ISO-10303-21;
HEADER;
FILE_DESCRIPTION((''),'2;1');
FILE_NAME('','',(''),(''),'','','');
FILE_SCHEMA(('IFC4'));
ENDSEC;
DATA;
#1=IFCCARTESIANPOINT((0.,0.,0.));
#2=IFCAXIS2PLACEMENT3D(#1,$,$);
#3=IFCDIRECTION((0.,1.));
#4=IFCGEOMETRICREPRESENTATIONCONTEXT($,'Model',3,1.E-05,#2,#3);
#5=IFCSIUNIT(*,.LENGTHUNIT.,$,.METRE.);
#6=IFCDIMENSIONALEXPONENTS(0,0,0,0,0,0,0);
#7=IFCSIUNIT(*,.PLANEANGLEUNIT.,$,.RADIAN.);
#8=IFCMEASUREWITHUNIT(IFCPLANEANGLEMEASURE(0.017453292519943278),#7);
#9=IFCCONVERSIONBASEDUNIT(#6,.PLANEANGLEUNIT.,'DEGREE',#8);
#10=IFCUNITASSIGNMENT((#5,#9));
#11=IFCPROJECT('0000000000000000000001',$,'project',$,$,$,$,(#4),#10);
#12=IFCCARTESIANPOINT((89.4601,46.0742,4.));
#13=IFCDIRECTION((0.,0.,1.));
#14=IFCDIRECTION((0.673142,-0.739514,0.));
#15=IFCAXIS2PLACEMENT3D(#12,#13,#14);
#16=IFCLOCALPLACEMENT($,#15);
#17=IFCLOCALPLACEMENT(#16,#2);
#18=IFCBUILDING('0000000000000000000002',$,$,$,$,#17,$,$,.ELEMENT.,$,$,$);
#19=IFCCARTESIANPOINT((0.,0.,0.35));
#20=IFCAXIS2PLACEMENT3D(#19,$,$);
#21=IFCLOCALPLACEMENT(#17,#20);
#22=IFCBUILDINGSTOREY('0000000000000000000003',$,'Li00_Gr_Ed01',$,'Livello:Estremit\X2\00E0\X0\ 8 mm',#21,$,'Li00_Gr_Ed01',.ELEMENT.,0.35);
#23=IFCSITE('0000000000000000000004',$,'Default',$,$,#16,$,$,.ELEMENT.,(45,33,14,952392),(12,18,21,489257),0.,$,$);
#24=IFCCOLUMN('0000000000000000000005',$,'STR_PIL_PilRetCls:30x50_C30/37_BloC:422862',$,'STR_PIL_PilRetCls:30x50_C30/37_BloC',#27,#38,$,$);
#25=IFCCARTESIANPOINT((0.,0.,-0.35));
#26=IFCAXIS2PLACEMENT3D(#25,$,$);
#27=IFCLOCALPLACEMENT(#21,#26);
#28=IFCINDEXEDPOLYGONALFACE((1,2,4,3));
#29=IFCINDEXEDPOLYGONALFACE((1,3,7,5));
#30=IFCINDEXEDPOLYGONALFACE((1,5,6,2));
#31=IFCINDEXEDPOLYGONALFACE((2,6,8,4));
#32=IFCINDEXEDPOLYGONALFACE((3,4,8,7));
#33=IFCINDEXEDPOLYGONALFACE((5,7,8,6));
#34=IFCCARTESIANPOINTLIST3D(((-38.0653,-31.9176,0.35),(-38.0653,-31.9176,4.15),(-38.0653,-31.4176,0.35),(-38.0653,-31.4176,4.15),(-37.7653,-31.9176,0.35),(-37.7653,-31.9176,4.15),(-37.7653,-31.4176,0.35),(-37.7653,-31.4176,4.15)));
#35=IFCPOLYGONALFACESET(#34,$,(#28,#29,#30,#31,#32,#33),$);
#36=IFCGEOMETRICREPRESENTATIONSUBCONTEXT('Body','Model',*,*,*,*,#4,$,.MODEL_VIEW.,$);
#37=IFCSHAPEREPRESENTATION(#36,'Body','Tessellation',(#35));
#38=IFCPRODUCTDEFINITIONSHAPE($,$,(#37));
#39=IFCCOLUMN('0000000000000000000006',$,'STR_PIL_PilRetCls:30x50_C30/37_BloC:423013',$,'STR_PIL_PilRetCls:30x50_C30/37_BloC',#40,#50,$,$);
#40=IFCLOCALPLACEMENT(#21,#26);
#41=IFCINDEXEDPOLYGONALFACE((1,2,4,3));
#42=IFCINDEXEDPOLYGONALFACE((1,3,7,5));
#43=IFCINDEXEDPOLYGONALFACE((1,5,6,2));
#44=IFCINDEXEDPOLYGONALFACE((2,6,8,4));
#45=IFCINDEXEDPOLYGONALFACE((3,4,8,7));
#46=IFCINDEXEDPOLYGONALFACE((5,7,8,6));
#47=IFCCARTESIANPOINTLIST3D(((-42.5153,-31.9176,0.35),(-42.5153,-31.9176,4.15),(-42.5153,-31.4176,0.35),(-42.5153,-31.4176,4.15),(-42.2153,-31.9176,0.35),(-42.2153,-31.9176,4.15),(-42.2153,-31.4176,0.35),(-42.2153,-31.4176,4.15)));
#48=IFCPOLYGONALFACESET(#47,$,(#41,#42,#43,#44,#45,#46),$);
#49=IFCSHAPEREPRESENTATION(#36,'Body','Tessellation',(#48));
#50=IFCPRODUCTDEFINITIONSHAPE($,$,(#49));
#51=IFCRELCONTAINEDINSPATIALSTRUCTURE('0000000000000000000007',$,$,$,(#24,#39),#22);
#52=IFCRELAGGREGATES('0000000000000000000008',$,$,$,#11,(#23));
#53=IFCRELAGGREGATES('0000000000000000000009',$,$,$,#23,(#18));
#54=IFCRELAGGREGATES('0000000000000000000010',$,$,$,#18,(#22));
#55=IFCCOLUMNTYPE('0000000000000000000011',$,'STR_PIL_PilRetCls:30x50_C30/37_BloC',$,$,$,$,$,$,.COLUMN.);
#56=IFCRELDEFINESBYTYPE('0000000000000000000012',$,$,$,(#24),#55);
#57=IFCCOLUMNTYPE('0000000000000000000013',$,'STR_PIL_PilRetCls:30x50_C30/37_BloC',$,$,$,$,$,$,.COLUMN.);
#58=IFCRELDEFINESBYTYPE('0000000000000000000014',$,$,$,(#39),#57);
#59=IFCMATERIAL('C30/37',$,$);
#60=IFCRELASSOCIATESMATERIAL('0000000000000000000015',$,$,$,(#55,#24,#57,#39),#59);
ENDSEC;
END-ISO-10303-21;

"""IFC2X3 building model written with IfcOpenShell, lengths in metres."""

from ifc_helpers import new_model, entity, si_unit, converted_unit, direction, frame, frame_2d, origin, place, context, subcontext, project, spatial, rectangle, extrude, source, transform, mapped, material, type_object, type_shapes, element, save


model = new_model("IFC2X3")

# Units and contexts
model_context = context("Model", 3, precision=1e-05, world=origin(), true_north=direction((0.0, 1.0)))
body_context = subcontext(model_context, "Body", "Model", "MODEL_VIEW")
ifc_project = project(units=[si_unit("LENGTHUNIT", "METRE"), converted_unit("PLANEANGLEUNIT", "DEGREE", entity("IfcPlaneAngleMeasure", 0.017453292519943278), si_unit("PLANEANGLEUNIT", "RADIAN"), dimensions=[0, 0, 0, 0, 0, 0, 0])], contexts=[model_context])

# Site, building, storey
site_placement = place(None, frame((89.4601, 46.0742, 4.0), z_axis=(0.0, 0.0, 1.0), x_axis=(0.673142, -0.739514, 0.0)))
site = spatial("IfcSite", under=ifc_project, at=site_placement, Name="Default", CompositionType="ELEMENT", RefLatitude=(45, 33, 14, 952392), RefLongitude=(12, 18, 21, 489257), RefElevation=0.0)
building_placement = place(site_placement, origin())
building = spatial("IfcBuilding", under=site, at=building_placement, CompositionType="ELEMENT")
storey_placement = place(building_placement, frame((0.0, 0.0, 0.35)))
storey = spatial("IfcBuildingStorey", under=building, at=storey_placement, Name="Li00_Gr_Ed01", ObjectType="Livello:Estremità 8 mm", LongName="Li00_Gr_Ed01", CompositionType="ELEMENT", Elevation=0.35)

# Columns
ifc_material_1 = material(Name="C30/37")
column_type_1 = type_object("IfcColumnType", Name="STR_PIL_PilRetCls:30x50_C30/37_BloC", PredefinedType="COLUMN", material=ifc_material_1)
shared_shape_1 = source(origin(), body_context, "Body", "SweptSolid", [
    extrude(rectangle(XDim=0.3, YDim=0.5, at=frame_2d((0.0, 0.0), x_axis=(1.0, 0.0))), frame((-37.9153, -31.6676, 0.35)), (0.0, 0.0, 1.0), 3.8),
])
type_shapes(column_type_1, [shared_shape_1])
column_1_placement = place(storey_placement, frame((0.0, 0.0, -0.35)))
element("IfcColumn", 1, at=column_1_placement, inside=storey, type_object=column_type_1, material=ifc_material_1, Name="STR_PIL_PilRetCls:30x50_C30/37_BloC:422862", ObjectType="STR_PIL_PilRetCls:30x50_C30/37_BloC", context=body_context, shape_type="MappedRepresentation", body=[
    mapped(shared_shape_1, transform((0.0, 0.0, 0.0), scale=1.0)),
])
column_type_2 = type_object("IfcColumnType", Name="STR_PIL_PilRetCls:30x50_C30/37_BloC", PredefinedType="COLUMN", material=ifc_material_1)
shared_shape_2 = source(origin(), body_context, "Body", "SweptSolid", [
    extrude(rectangle(XDim=0.3, YDim=0.5, at=frame_2d((0.0, 0.0), x_axis=(1.0, 0.0))), frame((-42.3653, -31.6676, 0.35)), (0.0, 0.0, 1.0), 3.8),
])
type_shapes(column_type_2, [shared_shape_2])
column_2_placement = place(storey_placement, frame((0.0, 0.0, -0.35)))
element("IfcColumn", 2, at=column_2_placement, inside=storey, type_object=column_type_2, material=ifc_material_1, Name="STR_PIL_PilRetCls:30x50_C30/37_BloC:423013", ObjectType="STR_PIL_PilRetCls:30x50_C30/37_BloC", context=body_context, shape_type="MappedRepresentation", body=[
    mapped(shared_shape_2, transform((0.0, 0.0, 0.0), scale=1.0)),
])

save(model, "model.ifc")
